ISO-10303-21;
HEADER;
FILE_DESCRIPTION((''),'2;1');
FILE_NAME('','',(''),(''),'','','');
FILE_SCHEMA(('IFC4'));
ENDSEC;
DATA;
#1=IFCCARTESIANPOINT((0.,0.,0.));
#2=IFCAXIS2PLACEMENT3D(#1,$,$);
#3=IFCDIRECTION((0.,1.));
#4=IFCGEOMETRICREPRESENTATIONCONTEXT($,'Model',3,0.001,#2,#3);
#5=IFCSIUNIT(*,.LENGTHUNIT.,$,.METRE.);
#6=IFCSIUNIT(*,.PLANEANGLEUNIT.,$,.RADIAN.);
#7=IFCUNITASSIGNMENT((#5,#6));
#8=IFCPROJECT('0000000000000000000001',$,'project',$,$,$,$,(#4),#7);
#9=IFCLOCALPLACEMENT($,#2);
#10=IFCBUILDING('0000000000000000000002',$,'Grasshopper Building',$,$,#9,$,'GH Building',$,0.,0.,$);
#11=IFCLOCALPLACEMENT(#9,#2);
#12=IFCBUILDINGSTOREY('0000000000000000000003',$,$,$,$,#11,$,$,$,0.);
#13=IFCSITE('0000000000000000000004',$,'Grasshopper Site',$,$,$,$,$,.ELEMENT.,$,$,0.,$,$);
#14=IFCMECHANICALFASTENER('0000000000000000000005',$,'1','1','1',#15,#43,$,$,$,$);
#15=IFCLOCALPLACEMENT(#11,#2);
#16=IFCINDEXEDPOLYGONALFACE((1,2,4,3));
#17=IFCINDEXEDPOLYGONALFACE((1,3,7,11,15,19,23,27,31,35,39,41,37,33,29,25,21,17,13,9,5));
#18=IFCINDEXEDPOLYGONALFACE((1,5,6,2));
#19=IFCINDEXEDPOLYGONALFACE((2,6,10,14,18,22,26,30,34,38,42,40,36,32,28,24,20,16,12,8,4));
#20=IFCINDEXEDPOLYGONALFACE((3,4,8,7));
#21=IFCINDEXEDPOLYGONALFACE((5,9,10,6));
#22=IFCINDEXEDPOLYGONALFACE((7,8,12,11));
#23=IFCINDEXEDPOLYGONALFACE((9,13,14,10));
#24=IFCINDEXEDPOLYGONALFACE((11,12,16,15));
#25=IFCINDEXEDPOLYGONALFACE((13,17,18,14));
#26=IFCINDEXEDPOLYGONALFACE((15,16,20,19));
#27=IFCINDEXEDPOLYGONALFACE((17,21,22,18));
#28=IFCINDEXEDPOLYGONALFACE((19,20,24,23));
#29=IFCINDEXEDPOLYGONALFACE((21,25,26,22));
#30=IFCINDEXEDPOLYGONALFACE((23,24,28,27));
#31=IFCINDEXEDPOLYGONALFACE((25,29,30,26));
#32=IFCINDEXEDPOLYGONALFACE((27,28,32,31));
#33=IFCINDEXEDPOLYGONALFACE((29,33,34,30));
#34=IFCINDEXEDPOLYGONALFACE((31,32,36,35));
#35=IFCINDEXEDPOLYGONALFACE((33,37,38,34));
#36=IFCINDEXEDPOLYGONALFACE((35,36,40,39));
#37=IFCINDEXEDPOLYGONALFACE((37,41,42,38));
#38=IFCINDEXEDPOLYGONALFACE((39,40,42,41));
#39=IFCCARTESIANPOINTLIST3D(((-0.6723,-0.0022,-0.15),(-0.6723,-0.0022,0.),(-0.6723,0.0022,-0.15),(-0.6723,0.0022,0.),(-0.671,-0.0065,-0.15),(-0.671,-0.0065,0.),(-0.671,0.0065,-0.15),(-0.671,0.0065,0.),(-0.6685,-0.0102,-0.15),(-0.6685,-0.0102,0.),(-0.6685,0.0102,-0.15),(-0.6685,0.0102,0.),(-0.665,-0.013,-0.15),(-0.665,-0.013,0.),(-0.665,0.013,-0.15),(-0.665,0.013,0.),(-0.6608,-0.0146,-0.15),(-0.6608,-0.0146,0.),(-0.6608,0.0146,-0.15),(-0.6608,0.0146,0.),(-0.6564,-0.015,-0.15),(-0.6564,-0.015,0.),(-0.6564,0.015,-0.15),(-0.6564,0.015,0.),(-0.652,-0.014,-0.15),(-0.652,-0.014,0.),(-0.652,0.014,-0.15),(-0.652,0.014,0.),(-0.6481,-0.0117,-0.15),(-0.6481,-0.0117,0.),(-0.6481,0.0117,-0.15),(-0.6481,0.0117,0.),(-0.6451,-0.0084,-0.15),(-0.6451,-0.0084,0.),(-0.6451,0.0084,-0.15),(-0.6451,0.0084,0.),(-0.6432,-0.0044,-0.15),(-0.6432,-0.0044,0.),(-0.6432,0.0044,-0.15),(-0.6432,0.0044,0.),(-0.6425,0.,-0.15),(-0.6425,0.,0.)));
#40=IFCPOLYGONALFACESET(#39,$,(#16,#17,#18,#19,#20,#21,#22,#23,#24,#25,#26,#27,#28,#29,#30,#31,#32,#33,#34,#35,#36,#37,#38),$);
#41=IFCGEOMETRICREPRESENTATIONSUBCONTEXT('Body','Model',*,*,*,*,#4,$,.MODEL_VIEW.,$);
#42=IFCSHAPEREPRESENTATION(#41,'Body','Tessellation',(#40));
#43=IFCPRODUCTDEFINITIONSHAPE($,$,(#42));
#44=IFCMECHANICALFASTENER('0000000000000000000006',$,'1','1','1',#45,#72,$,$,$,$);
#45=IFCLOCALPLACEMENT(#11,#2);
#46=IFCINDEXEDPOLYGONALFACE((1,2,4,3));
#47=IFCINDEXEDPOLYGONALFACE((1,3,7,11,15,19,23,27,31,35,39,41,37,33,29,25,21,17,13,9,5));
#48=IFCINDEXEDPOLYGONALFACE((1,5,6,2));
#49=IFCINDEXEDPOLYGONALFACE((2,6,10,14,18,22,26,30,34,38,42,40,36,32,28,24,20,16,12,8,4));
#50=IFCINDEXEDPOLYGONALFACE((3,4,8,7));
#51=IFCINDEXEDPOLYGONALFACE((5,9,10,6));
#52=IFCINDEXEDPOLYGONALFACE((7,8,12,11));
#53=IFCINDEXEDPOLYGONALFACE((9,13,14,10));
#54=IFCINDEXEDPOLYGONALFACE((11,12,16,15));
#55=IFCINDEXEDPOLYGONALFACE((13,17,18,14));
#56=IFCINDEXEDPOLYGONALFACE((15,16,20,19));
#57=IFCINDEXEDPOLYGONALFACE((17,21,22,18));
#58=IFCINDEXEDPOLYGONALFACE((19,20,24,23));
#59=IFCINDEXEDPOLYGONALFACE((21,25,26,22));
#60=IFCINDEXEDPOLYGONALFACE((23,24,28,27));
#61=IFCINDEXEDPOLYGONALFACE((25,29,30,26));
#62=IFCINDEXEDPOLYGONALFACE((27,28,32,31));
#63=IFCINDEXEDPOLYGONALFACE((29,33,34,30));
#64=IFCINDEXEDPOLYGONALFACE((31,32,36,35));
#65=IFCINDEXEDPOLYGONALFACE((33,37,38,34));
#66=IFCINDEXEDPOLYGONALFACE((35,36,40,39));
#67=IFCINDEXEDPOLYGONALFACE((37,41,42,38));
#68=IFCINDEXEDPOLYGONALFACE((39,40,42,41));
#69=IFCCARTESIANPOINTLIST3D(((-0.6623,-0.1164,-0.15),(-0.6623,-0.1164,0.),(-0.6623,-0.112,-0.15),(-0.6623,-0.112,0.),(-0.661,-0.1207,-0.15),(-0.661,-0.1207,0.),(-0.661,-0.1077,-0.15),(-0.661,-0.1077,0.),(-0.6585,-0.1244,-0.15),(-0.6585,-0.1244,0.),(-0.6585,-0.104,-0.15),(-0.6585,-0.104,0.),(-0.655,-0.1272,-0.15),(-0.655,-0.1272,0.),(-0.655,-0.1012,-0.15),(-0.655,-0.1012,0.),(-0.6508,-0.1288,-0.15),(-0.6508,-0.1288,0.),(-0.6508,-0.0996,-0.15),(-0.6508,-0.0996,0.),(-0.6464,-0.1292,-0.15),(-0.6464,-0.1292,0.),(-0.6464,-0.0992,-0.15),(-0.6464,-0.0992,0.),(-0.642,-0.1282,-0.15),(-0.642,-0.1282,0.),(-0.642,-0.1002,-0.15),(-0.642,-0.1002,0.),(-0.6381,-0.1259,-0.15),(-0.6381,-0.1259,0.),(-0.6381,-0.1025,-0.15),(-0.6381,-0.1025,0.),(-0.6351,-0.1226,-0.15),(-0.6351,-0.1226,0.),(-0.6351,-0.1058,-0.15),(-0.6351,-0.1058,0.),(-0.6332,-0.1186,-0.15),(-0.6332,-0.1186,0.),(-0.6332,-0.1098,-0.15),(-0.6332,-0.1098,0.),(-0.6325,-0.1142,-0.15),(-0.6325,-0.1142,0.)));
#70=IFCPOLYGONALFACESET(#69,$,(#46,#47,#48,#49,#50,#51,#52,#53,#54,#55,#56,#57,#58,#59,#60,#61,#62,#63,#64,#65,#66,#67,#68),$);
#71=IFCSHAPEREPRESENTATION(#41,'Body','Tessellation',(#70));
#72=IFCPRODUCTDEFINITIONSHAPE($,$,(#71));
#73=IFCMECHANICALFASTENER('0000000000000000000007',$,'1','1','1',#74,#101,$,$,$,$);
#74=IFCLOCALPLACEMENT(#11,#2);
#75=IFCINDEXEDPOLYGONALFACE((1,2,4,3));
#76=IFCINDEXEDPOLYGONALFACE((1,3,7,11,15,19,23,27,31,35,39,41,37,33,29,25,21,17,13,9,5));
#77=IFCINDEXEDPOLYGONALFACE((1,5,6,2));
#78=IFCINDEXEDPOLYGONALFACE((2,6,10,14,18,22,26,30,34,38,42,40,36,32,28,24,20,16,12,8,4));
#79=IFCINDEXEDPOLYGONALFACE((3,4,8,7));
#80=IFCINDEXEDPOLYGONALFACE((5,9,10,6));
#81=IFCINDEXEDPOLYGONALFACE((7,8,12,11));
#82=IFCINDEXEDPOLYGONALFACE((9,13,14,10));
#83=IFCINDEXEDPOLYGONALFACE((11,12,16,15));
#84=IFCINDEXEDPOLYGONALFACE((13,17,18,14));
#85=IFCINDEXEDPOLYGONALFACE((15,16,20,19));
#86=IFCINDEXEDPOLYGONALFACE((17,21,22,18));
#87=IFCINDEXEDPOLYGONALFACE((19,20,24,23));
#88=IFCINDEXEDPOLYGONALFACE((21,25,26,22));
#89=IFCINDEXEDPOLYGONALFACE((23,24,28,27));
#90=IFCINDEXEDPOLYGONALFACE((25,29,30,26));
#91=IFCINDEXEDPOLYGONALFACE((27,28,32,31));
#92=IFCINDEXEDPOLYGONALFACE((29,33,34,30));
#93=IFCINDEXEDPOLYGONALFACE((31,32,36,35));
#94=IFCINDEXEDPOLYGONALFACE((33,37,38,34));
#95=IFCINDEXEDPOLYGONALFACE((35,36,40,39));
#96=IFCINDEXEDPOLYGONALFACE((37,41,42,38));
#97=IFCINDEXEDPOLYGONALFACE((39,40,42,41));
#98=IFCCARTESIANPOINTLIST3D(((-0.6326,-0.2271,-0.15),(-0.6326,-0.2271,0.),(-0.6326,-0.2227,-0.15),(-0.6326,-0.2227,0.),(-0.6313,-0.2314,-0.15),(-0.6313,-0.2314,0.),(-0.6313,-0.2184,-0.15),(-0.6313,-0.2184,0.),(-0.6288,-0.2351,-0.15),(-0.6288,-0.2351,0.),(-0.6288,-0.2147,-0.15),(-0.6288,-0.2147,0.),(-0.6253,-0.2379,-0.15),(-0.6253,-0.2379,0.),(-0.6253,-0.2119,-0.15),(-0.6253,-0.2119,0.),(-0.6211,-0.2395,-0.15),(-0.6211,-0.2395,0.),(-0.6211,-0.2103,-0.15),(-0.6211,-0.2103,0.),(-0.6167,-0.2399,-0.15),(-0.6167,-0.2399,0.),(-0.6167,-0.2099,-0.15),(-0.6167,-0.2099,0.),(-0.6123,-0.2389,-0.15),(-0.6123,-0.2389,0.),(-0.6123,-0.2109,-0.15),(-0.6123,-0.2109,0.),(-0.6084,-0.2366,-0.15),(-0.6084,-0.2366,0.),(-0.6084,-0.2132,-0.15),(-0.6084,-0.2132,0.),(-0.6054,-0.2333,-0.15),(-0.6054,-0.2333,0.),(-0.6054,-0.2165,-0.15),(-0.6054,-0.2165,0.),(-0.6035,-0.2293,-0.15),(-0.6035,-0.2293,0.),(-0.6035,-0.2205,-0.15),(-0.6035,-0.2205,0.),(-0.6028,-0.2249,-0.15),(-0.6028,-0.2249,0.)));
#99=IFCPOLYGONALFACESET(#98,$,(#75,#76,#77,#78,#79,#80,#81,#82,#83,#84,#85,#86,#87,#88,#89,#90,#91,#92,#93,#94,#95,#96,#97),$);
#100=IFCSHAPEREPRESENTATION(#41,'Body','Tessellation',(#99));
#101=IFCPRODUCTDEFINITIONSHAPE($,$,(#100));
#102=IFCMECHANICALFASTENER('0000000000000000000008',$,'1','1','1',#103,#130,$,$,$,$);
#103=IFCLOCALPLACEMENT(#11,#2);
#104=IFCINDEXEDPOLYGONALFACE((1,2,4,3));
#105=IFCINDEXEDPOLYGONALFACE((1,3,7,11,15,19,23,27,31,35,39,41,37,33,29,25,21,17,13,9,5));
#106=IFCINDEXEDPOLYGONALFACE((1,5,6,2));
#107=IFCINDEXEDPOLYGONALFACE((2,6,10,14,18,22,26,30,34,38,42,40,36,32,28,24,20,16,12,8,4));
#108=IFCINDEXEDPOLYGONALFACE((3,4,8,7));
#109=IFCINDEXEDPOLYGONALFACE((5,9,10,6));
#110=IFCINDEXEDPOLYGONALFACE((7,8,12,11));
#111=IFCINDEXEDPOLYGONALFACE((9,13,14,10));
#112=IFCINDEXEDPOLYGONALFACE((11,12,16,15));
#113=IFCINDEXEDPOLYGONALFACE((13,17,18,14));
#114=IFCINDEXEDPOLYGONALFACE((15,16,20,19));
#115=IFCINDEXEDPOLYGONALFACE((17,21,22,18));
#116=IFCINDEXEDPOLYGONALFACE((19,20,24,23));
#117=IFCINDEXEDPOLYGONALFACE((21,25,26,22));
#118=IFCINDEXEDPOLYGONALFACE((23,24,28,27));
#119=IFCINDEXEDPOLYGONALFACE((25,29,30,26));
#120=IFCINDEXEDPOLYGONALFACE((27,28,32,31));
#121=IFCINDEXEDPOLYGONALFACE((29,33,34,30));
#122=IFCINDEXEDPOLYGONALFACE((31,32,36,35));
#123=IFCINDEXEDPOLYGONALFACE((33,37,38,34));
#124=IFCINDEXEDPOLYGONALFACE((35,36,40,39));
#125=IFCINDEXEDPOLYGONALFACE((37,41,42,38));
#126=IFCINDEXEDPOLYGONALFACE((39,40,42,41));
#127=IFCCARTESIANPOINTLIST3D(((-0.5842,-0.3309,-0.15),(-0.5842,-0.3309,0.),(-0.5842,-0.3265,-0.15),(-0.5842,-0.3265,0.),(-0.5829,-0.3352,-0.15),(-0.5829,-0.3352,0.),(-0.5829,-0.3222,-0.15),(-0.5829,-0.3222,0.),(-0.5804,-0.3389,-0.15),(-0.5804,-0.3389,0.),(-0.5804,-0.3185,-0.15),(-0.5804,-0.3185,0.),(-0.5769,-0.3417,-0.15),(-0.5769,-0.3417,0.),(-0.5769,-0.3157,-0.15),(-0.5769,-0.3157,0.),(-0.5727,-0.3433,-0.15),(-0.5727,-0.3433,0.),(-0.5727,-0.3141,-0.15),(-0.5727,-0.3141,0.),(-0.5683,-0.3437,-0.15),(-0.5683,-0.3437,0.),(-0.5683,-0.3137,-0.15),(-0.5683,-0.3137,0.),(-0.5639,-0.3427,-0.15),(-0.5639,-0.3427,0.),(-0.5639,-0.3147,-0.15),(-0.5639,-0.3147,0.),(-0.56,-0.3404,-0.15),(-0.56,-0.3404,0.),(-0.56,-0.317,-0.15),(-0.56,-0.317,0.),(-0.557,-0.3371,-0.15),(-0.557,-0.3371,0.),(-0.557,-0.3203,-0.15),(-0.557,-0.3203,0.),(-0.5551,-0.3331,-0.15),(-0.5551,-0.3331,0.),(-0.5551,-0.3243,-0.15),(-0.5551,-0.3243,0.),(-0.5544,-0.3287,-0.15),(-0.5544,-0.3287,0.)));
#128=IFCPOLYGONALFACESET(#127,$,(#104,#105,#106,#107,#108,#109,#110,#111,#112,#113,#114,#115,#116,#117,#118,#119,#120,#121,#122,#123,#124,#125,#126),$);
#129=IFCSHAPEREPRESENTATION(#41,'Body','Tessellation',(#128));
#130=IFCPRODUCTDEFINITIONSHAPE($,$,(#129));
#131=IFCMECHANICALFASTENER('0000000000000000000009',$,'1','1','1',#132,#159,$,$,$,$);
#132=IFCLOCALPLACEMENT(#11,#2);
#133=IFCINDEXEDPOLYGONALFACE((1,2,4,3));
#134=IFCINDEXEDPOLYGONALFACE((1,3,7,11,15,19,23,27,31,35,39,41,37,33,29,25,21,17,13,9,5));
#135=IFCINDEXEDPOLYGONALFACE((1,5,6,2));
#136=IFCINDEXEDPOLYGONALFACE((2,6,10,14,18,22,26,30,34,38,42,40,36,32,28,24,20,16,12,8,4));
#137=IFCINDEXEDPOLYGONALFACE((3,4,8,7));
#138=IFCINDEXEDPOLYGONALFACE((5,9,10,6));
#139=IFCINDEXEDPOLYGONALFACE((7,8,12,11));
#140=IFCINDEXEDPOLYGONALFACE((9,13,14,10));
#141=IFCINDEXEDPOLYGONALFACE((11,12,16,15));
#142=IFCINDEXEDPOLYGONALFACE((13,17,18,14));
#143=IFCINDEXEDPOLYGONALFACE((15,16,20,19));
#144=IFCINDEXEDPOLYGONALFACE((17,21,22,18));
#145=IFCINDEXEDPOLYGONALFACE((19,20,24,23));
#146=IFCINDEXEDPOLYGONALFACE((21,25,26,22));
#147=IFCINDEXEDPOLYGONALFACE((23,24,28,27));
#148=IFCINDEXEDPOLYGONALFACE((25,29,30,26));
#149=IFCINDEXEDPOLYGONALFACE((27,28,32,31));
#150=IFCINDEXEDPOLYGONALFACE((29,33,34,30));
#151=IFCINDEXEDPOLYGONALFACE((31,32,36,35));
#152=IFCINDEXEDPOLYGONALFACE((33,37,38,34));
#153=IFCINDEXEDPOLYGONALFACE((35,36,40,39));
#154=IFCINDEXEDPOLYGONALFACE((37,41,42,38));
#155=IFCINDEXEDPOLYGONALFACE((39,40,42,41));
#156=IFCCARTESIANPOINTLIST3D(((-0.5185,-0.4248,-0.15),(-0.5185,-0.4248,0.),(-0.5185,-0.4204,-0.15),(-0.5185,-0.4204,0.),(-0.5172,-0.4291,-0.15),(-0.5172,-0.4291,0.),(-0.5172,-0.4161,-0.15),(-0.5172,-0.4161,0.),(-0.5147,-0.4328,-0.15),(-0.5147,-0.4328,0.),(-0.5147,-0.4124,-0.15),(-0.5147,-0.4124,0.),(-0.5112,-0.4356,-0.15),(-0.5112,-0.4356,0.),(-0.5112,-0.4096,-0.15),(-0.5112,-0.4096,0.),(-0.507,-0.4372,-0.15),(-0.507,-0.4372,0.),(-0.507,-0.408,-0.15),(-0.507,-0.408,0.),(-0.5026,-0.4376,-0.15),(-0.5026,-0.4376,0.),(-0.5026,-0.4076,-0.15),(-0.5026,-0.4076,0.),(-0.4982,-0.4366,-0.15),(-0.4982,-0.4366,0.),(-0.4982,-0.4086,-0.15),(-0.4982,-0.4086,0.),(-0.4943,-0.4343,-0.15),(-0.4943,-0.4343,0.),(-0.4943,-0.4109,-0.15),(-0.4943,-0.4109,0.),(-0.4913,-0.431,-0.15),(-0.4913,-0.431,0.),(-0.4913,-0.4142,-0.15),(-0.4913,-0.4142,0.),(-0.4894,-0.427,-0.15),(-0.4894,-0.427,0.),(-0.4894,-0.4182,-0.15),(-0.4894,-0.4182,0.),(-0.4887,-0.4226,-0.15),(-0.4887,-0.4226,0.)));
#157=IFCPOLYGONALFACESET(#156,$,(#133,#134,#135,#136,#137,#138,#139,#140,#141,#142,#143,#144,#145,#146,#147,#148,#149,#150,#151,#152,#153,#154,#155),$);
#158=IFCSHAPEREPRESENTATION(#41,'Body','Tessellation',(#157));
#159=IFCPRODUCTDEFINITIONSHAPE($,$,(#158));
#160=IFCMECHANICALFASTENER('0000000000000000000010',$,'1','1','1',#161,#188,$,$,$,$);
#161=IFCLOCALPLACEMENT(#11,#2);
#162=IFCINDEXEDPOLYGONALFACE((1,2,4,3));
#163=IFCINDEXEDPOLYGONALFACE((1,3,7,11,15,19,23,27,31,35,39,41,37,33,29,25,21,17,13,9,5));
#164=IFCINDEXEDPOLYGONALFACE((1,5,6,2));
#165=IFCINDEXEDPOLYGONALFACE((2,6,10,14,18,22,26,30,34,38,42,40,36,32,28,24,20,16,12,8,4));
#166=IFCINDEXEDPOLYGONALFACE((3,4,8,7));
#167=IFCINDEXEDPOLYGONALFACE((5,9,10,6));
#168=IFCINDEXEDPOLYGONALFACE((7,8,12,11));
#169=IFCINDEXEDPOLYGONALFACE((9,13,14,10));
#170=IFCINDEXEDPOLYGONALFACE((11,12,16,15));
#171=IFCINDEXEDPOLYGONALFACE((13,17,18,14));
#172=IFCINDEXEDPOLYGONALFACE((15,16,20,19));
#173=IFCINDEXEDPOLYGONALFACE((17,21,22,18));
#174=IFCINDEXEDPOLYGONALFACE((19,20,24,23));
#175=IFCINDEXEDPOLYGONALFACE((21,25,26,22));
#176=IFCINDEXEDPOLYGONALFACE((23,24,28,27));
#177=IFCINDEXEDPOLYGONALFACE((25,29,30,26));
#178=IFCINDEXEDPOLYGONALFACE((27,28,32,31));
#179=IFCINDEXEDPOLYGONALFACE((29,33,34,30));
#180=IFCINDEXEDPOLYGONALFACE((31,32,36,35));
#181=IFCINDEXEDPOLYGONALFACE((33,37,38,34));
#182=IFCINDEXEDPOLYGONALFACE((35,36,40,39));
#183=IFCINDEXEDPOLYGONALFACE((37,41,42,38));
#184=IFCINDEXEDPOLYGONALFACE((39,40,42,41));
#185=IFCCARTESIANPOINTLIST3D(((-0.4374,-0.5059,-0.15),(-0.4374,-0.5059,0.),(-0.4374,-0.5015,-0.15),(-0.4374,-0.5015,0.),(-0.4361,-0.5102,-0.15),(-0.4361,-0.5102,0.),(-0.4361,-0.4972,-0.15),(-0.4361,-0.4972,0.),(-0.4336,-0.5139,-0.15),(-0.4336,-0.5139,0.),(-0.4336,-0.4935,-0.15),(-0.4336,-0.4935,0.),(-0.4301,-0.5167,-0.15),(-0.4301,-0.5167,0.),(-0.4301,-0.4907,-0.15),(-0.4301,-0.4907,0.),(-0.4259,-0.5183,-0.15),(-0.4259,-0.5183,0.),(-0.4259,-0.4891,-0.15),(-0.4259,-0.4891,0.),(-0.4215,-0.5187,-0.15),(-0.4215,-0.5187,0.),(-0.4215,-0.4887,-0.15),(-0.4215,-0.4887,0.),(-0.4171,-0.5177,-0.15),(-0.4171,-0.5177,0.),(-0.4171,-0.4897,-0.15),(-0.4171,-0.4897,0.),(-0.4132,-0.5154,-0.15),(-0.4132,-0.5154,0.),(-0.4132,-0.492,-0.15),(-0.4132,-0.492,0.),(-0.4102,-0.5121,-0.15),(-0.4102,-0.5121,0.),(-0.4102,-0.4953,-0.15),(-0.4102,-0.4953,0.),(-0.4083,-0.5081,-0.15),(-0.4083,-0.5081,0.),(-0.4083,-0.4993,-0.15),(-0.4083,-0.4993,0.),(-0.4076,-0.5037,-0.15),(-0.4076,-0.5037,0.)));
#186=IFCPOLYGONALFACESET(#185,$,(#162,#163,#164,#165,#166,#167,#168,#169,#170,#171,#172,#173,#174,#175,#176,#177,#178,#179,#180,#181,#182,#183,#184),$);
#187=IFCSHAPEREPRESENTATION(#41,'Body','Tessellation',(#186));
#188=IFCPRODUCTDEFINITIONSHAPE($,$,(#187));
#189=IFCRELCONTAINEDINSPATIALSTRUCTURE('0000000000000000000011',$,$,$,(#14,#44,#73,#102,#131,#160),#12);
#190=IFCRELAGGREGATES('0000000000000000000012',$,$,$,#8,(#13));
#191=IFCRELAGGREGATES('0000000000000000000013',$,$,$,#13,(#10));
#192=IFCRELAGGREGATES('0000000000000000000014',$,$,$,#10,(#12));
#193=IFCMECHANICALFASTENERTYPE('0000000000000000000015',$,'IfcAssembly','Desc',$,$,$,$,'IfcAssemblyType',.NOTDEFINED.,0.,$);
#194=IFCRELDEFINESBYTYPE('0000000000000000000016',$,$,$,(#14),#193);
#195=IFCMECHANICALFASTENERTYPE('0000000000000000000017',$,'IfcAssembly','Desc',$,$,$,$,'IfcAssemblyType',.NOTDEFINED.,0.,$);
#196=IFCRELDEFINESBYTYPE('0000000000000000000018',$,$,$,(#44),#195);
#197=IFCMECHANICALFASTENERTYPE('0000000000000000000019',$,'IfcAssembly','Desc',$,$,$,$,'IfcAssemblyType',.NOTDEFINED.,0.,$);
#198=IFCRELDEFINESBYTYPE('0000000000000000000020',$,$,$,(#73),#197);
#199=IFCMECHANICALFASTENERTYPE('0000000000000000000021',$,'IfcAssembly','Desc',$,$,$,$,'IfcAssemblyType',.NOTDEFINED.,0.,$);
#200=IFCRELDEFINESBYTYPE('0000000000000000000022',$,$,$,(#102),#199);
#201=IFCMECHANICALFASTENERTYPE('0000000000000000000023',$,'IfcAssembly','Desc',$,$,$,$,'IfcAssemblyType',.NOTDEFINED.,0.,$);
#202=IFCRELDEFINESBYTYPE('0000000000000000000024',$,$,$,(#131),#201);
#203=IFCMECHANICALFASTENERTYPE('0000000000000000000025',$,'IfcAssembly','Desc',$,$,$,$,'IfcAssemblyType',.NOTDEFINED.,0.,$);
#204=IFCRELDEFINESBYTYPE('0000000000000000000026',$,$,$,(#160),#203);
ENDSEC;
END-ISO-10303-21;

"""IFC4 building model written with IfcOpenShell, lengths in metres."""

from ifc_helpers import new_model, si_unit, direction, frame, origin, place, context, subcontext, project, spatial, circle, extrude, source, transform, mapped, type_object, type_shapes, element, save


model = new_model("IFC4")

# Units and contexts
model_context = context("Model", 3, precision=0.001, world=origin(), true_north=direction((0.0, 1.0)))
body_context = subcontext(model_context, "Body", "Model", "MODEL_VIEW")
ifc_project = project(units=[si_unit("LENGTHUNIT", "METRE"), si_unit("PLANEANGLEUNIT", "RADIAN")], contexts=[model_context])

# Site, building, storey
site = spatial("IfcSite", under=ifc_project, Name="Grasshopper Site", CompositionType="ELEMENT", RefElevation=0.0)
building_placement = place(None, origin())
building = spatial("IfcBuilding", under=site, at=building_placement, Name="Grasshopper Building", LongName="GH Building", ElevationOfRefHeight=0.0, ElevationOfTerrain=0.0)
storey_placement = place(building_placement, origin())
storey = spatial("IfcBuildingStorey", under=building, at=storey_placement, Elevation=0.0)

# Mechanical fasteners
mechanical_fastener_type_1 = type_object("IfcMechanicalFastenerType", Name="IfcAssembly", Description="Desc", ElementType="IfcAssemblyType", NominalDiameter=0.0)
shared_shape_1 = source(origin(), body_context, "Body", "SweptSolid", [
    extrude(circle(Radius=0.015), frame((-0.6575, 0.0, 0.0), z_axis=(0.0, 0.0, -1.0), x_axis=(1.0, 0.0, 0.0)), (0.0, 0.0, 1.0), 0.15),
])
type_shapes(mechanical_fastener_type_1, [shared_shape_1])
mechanical_fastener_1_placement = place(storey_placement, origin())
element("IfcMechanicalFastener", 1, at=mechanical_fastener_1_placement, inside=storey, type_object=mechanical_fastener_type_1, Name="1", Description="1", ObjectType="1", context=body_context, shape_type="MappedRepresentation", body=[
    mapped(shared_shape_1, transform((0.0, 0.0, 0.0), scale=1.0)),
])
mechanical_fastener_type_2 = type_object("IfcMechanicalFastenerType", Name="IfcAssembly", Description="Desc", ElementType="IfcAssemblyType", NominalDiameter=0.0)
shared_shape_2 = source(origin(), body_context, "Body", "SweptSolid", [
    extrude(circle(Radius=0.015), frame((-0.6475, -0.1142, 0.0), z_axis=(0.0, 0.0, -1.0), x_axis=(1.0, 0.0, 0.0)), (0.0, 0.0, 1.0), 0.15),
])
type_shapes(mechanical_fastener_type_2, [shared_shape_2])
mechanical_fastener_2_placement = place(storey_placement, origin())
element("IfcMechanicalFastener", 2, at=mechanical_fastener_2_placement, inside=storey, type_object=mechanical_fastener_type_2, Name="1", Description="1", ObjectType="1", context=body_context, shape_type="MappedRepresentation", body=[
    mapped(shared_shape_2, transform((0.0, 0.0, 0.0), scale=1.0)),
])
mechanical_fastener_type_3 = type_object("IfcMechanicalFastenerType", Name="IfcAssembly", Description="Desc", ElementType="IfcAssemblyType", NominalDiameter=0.0)
shared_shape_3 = source(origin(), body_context, "Body", "SweptSolid", [
    extrude(circle(Radius=0.015), frame((-0.6178, -0.2249, 0.0), z_axis=(0.0, 0.0, -1.0), x_axis=(1.0, 0.0, 0.0)), (0.0, 0.0, 1.0), 0.15),
])
type_shapes(mechanical_fastener_type_3, [shared_shape_3])
mechanical_fastener_3_placement = place(storey_placement, origin())
element("IfcMechanicalFastener", 3, at=mechanical_fastener_3_placement, inside=storey, type_object=mechanical_fastener_type_3, Name="1", Description="1", ObjectType="1", context=body_context, shape_type="MappedRepresentation", body=[
    mapped(shared_shape_3, transform((0.0, 0.0, 0.0), scale=1.0)),
])
mechanical_fastener_type_4 = type_object("IfcMechanicalFastenerType", Name="IfcAssembly", Description="Desc", ElementType="IfcAssemblyType", NominalDiameter=0.0)
shared_shape_4 = source(origin(), body_context, "Body", "SweptSolid", [
    extrude(circle(Radius=0.015), frame((-0.5694, -0.3287, 0.0), z_axis=(0.0, 0.0, -1.0), x_axis=(1.0, 0.0, 0.0)), (0.0, 0.0, 1.0), 0.15),
])
type_shapes(mechanical_fastener_type_4, [shared_shape_4])
mechanical_fastener_4_placement = place(storey_placement, origin())
element("IfcMechanicalFastener", 4, at=mechanical_fastener_4_placement, inside=storey, type_object=mechanical_fastener_type_4, Name="1", Description="1", ObjectType="1", context=body_context, shape_type="MappedRepresentation", body=[
    mapped(shared_shape_4, transform((0.0, 0.0, 0.0), scale=1.0)),
])
mechanical_fastener_type_5 = type_object("IfcMechanicalFastenerType", Name="IfcAssembly", Description="Desc", ElementType="IfcAssemblyType", NominalDiameter=0.0)
shared_shape_5 = source(origin(), body_context, "Body", "SweptSolid", [
    extrude(circle(Radius=0.015), frame((-0.5037, -0.4226, 0.0), z_axis=(0.0, 0.0, -1.0), x_axis=(1.0, 0.0, 0.0)), (0.0, 0.0, 1.0), 0.15),
])
type_shapes(mechanical_fastener_type_5, [shared_shape_5])
mechanical_fastener_5_placement = place(storey_placement, origin())
element("IfcMechanicalFastener", 5, at=mechanical_fastener_5_placement, inside=storey, type_object=mechanical_fastener_type_5, Name="1", Description="1", ObjectType="1", context=body_context, shape_type="MappedRepresentation", body=[
    mapped(shared_shape_5, transform((0.0, 0.0, 0.0), scale=1.0)),
])
mechanical_fastener_type_6 = type_object("IfcMechanicalFastenerType", Name="IfcAssembly", Description="Desc", ElementType="IfcAssemblyType", NominalDiameter=0.0)
shared_shape_6 = source(origin(), body_context, "Body", "SweptSolid", [
    extrude(circle(Radius=0.015), frame((-0.4226, -0.5037, 0.0), z_axis=(0.0, 0.0, -1.0), x_axis=(1.0, 0.0, 0.0)), (0.0, 0.0, 1.0), 0.15),
])
type_shapes(mechanical_fastener_type_6, [shared_shape_6])
mechanical_fastener_6_placement = place(storey_placement, origin())
element("IfcMechanicalFastener", 6, at=mechanical_fastener_6_placement, inside=storey, type_object=mechanical_fastener_type_6, Name="1", Description="1", ObjectType="1", context=body_context, shape_type="MappedRepresentation", body=[
    mapped(shared_shape_6, transform((0.0, 0.0, 0.0), scale=1.0)),
])

save(model, "model.ifc")
